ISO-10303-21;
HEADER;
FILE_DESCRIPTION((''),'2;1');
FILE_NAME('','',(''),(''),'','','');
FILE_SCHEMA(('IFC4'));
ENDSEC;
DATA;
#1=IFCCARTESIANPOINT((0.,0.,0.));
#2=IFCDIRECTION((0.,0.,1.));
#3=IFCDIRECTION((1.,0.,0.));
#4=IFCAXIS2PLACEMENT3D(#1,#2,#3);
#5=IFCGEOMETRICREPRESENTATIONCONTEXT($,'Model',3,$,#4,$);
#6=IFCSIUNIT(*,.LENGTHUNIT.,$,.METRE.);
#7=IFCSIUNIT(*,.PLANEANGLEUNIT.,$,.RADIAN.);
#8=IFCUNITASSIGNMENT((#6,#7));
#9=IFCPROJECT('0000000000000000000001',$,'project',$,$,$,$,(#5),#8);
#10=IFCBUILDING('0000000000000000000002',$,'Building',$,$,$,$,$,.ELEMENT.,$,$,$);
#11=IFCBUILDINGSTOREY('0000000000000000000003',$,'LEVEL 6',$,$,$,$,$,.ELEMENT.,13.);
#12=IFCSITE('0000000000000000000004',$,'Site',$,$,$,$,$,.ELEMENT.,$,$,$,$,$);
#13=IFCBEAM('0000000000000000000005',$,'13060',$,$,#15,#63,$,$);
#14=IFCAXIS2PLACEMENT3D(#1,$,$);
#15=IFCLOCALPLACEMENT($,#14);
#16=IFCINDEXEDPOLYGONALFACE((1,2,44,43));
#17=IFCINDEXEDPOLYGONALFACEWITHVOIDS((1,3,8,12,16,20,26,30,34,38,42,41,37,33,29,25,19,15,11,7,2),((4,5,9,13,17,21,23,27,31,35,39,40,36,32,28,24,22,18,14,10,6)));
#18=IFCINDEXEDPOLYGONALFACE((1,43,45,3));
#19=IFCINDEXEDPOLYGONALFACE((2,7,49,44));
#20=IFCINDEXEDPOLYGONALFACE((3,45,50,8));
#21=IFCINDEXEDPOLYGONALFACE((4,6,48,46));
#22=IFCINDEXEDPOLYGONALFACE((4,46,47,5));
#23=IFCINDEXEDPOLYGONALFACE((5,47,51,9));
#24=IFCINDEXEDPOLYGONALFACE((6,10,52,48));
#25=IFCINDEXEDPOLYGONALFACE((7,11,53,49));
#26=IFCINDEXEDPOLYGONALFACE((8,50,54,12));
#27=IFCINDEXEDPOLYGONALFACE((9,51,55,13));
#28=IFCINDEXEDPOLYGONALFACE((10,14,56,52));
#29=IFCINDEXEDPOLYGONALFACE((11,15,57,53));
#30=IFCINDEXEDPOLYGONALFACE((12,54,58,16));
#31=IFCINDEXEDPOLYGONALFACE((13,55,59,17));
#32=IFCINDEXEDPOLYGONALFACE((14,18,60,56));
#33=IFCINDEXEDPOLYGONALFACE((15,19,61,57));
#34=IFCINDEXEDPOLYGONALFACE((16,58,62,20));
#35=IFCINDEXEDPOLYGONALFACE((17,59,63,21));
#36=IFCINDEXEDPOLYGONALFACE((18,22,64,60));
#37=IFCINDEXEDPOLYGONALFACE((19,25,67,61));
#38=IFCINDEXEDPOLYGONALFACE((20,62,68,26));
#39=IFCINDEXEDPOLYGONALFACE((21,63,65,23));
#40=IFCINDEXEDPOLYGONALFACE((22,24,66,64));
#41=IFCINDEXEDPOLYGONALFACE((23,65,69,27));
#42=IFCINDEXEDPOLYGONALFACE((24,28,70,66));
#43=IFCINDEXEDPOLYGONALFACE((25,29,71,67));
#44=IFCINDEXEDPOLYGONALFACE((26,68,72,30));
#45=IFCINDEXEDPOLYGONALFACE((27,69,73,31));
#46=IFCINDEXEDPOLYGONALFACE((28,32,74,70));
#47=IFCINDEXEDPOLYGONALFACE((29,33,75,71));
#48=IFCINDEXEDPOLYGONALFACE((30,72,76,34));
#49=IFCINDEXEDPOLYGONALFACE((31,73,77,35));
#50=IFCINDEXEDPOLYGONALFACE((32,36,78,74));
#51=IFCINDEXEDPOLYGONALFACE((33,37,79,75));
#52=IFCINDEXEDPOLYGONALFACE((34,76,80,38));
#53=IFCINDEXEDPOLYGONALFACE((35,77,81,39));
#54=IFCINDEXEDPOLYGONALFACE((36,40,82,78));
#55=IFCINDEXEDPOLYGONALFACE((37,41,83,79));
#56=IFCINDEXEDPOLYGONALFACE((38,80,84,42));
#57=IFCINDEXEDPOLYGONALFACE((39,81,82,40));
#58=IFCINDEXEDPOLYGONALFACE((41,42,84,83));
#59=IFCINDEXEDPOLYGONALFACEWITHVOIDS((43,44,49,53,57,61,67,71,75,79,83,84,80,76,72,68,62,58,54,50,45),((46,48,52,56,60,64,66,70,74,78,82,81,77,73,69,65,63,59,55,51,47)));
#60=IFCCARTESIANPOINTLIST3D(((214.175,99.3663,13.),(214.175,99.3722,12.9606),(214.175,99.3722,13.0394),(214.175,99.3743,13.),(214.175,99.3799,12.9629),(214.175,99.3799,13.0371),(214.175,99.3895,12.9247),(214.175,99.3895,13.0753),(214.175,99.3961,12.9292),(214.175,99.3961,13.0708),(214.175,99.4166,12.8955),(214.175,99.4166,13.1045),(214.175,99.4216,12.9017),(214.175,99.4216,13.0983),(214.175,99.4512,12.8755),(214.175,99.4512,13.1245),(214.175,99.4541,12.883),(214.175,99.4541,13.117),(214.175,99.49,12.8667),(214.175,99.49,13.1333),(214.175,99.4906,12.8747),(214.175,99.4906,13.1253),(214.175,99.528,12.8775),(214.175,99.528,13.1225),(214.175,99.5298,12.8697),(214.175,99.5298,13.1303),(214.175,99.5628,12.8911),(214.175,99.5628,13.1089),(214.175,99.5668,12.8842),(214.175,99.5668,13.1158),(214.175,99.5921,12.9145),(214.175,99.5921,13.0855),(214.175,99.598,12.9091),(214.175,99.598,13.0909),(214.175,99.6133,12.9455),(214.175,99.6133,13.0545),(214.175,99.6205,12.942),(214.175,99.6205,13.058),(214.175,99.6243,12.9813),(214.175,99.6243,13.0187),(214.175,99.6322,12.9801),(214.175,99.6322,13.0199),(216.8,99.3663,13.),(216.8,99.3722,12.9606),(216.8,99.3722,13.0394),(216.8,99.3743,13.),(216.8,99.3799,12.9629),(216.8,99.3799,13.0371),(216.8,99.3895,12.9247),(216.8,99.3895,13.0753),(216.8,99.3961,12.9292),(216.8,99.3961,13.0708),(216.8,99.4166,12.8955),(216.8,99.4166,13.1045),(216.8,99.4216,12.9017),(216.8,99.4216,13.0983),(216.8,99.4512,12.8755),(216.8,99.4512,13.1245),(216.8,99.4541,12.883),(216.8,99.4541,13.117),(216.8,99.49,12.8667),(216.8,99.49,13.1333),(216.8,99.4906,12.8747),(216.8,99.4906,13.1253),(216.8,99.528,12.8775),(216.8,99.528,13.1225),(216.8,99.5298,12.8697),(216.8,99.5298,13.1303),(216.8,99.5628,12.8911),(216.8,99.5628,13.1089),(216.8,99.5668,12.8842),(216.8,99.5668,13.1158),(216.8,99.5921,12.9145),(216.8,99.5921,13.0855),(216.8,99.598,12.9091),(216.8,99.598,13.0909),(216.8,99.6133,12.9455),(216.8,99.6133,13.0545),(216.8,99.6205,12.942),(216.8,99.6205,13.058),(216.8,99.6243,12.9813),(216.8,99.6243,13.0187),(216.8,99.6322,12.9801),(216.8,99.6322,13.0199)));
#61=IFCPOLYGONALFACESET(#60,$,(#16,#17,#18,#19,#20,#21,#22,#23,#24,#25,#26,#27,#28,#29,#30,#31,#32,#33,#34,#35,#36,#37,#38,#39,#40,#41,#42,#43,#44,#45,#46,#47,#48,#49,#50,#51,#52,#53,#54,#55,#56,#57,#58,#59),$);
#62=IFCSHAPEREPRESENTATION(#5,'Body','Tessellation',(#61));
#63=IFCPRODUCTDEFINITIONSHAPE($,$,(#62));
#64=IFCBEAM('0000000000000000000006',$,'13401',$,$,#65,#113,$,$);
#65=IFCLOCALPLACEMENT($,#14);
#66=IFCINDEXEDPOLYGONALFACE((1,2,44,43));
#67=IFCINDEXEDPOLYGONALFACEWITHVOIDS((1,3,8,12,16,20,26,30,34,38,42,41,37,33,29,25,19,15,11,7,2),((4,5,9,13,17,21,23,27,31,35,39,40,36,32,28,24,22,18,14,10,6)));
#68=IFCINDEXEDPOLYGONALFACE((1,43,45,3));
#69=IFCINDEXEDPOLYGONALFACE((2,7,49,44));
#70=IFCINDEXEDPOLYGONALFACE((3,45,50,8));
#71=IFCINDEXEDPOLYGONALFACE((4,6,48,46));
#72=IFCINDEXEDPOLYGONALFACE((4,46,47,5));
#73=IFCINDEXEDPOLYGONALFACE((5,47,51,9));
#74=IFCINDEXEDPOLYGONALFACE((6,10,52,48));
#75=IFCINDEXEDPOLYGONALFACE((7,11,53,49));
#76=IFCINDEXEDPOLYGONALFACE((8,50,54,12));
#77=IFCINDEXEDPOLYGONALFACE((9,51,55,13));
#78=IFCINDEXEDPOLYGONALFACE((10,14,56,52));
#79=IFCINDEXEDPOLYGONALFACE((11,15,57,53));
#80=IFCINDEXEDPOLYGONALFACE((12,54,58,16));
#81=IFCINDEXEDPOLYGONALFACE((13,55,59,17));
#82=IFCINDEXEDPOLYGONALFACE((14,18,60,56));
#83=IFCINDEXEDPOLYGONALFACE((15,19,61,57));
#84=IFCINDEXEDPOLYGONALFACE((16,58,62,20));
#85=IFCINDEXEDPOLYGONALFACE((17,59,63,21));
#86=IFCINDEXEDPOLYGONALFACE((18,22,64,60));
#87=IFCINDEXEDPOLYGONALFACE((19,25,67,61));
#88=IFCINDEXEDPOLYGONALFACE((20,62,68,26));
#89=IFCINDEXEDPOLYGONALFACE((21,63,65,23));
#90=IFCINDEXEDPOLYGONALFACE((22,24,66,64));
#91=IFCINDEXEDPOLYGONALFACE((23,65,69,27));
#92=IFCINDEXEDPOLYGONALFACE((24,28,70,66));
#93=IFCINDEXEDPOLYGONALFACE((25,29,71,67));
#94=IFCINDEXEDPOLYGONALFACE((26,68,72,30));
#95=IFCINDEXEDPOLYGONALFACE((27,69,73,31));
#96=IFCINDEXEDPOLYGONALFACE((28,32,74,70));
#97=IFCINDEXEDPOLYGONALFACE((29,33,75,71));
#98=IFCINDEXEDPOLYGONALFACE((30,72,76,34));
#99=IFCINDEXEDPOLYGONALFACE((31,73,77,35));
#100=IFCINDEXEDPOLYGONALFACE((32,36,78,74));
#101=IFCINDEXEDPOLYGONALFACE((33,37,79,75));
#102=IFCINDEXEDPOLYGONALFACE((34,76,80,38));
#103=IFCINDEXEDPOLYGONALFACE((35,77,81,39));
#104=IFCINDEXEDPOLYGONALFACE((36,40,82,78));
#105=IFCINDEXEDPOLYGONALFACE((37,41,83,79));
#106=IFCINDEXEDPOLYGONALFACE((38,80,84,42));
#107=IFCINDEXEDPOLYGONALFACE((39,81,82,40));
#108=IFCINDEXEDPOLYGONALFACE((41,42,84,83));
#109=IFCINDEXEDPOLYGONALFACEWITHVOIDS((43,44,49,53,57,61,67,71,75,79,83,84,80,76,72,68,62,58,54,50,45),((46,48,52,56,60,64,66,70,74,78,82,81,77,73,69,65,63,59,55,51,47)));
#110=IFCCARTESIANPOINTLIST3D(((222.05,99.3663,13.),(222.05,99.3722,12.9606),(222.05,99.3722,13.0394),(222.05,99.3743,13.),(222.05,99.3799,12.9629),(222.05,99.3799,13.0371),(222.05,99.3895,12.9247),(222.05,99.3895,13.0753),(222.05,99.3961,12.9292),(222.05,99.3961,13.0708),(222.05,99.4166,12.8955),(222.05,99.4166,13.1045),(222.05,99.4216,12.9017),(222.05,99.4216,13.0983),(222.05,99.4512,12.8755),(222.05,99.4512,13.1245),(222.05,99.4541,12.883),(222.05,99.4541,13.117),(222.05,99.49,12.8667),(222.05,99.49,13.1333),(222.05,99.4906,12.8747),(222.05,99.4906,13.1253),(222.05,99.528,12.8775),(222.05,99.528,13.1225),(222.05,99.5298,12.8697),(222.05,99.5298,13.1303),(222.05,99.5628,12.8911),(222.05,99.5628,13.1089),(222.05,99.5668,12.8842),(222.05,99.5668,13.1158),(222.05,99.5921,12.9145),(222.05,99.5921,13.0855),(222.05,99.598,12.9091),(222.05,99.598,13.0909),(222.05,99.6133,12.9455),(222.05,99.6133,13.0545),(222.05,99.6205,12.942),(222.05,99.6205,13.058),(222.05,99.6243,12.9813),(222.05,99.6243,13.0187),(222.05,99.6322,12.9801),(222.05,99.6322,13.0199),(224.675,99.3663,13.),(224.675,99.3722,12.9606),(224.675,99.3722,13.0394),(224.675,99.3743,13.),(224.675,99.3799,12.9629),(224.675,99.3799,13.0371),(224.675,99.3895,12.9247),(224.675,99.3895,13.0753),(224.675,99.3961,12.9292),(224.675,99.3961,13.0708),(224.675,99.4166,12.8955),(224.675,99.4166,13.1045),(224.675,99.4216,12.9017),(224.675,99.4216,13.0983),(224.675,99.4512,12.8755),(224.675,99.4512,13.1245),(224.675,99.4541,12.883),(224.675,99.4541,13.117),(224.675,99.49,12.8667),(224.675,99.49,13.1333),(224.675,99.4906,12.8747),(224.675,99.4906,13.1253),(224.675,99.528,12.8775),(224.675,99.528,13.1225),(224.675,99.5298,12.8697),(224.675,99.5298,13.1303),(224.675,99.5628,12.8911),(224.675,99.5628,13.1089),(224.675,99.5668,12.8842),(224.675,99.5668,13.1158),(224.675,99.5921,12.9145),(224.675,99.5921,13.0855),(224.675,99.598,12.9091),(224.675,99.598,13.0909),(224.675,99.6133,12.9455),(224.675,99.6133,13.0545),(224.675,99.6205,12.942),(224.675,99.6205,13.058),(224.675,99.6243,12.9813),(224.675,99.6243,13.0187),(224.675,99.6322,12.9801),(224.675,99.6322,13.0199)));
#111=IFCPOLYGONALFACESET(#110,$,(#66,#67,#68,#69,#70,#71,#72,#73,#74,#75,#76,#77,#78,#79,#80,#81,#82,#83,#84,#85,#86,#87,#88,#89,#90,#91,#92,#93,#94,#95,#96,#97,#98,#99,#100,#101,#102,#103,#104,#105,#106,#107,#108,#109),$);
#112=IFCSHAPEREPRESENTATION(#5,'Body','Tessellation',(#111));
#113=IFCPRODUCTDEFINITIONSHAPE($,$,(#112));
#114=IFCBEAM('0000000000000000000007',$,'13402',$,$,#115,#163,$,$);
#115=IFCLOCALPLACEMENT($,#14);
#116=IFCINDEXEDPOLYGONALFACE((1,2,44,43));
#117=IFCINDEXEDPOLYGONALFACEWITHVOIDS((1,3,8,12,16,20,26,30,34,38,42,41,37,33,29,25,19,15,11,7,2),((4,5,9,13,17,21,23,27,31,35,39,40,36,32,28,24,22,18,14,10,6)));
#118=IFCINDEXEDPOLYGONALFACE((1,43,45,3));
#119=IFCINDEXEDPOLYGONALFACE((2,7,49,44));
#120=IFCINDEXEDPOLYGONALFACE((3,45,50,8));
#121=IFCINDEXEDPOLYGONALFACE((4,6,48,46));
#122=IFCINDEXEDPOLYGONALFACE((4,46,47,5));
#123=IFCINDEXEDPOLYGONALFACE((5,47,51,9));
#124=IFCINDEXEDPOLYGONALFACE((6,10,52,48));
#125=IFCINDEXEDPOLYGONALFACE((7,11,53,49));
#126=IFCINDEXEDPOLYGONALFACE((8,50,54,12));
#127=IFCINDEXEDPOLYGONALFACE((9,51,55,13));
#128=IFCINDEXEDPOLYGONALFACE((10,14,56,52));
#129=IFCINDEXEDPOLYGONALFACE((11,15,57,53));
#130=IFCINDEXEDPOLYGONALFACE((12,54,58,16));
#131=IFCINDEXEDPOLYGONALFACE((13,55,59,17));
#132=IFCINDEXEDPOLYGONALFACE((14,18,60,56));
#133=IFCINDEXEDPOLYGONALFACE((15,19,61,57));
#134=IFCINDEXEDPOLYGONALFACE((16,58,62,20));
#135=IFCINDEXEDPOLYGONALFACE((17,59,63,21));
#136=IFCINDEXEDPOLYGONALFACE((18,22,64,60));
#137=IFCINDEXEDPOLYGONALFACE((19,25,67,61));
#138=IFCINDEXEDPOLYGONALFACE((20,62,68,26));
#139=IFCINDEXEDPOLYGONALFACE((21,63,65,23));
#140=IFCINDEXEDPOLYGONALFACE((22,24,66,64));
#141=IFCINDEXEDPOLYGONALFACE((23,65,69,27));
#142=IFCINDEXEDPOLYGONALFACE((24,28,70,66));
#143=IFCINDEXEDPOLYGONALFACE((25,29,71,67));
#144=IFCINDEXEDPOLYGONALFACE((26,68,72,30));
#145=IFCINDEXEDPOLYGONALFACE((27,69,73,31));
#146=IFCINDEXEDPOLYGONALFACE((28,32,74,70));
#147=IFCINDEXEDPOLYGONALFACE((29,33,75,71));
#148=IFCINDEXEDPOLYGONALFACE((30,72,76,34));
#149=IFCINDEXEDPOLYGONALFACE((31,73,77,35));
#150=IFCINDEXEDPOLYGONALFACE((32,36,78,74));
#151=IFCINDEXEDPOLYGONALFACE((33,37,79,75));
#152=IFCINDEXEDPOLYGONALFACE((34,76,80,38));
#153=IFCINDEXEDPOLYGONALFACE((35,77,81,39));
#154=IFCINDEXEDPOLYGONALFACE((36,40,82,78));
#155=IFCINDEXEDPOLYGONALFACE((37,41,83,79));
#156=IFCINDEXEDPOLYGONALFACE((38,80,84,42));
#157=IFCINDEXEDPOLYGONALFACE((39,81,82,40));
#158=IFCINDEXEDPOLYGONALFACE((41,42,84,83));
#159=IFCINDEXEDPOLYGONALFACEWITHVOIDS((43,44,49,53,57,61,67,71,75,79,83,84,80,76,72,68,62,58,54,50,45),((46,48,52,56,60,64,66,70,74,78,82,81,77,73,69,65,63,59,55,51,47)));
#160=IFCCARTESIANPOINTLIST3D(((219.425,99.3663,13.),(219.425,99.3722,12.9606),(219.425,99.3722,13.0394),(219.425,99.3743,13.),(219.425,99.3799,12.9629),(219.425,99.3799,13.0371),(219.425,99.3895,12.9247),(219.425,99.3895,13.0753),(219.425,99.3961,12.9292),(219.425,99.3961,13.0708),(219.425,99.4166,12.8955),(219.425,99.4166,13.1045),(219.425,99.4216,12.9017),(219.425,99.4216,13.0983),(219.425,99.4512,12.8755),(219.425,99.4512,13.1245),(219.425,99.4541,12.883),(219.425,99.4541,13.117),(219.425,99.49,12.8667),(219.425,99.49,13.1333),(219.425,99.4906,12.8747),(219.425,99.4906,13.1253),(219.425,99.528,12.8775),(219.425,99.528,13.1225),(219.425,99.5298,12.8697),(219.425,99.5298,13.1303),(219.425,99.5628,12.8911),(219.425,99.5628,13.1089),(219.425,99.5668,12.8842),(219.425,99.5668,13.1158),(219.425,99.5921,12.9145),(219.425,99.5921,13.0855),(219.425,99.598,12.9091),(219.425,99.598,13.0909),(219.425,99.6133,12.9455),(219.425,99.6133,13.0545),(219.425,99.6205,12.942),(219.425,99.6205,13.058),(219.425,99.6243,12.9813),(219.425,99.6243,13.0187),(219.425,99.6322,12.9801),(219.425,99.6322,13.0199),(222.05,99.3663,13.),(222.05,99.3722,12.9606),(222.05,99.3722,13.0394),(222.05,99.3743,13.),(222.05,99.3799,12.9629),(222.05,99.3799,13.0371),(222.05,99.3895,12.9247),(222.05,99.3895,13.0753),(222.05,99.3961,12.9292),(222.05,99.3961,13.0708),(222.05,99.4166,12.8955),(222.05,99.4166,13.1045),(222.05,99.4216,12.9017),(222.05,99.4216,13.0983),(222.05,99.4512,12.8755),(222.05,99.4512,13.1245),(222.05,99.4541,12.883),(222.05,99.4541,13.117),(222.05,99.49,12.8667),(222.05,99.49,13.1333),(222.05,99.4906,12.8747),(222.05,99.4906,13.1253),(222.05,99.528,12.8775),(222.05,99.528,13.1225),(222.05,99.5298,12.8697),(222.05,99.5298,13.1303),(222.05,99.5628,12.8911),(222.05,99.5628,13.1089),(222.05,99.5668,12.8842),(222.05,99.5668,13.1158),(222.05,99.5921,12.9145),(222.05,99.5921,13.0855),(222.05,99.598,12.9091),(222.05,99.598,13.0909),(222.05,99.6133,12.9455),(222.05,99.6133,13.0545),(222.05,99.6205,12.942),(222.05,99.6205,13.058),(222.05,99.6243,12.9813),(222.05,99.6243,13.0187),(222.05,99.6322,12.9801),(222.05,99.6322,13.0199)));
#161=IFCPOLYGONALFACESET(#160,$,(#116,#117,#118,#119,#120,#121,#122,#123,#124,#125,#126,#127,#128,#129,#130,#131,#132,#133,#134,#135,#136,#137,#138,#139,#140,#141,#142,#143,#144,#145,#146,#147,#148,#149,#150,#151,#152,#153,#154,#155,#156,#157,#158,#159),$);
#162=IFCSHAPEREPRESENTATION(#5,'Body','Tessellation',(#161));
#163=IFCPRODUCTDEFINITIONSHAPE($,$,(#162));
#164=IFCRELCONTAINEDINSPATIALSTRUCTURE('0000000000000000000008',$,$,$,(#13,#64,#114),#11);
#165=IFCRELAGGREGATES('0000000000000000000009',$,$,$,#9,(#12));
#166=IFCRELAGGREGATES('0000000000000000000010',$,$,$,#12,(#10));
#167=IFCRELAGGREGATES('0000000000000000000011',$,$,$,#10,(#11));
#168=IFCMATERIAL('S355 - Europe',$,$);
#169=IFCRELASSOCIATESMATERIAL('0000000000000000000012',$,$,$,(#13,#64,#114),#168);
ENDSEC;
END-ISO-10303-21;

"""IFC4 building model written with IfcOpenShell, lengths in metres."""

from ifc_helpers import new_model, si_unit, frame, origin_with_axes, origin_2d_with_axis, place, context, project, spatial, hollow_circle, extrude, material, material_profile, profile_set, profile_usage, element, save


model = new_model("IFC4")

# Units and contexts
model_context = context("Model", 3, world=origin_with_axes())
ifc_project = project(units=[si_unit("LENGTHUNIT", "METRE"), si_unit("PLANEANGLEUNIT", "RADIAN")], contexts=[model_context])

# Site, building, storey
site = spatial("IfcSite", under=ifc_project, Name="Site", CompositionType="ELEMENT")
building = spatial("IfcBuilding", under=site, Name="Building", CompositionType="ELEMENT")
storey = spatial("IfcBuildingStorey", under=building, Name="LEVEL 6", CompositionType="ELEMENT", Elevation=13.0)

# Shared definitions
ifc_material = material(Name="S355 - Europe")

# Beams
ifc_material_profile_1 = material_profile(ifc_material, hollow_circle(Radius=0.1337, WallThickness=0.008, at=origin_2d_with_axis()))
ifc_profile_set_1 = profile_set([ifc_material_profile_1])
ifc_profile_usage_1 = profile_usage(ifc_profile_set_1, cardinal=10)
beam_1_placement = place(None, frame((216.8, 99.5, 13.0), z_axis=(-1.0, 0.0, 0.0), x_axis=(0.0, -1.0, 0.0)))
element("IfcBeam", 1, at=beam_1_placement, inside=storey, material=ifc_profile_usage_1, Name="13060", context=model_context, shape_type="SweptSolid", body=[
    extrude(hollow_circle(Radius=0.1337, WallThickness=0.008, at=origin_2d_with_axis()), origin_with_axes(), (0.0, 0.0, 1.0), 2.625),
])
ifc_material_profile_2 = material_profile(ifc_material, hollow_circle(Radius=0.1337, WallThickness=0.008, at=origin_2d_with_axis()))
ifc_profile_set_2 = profile_set([ifc_material_profile_2])
ifc_profile_usage_2 = profile_usage(ifc_profile_set_2, cardinal=10)
beam_2_placement = place(None, frame((224.675, 99.5, 13.0), z_axis=(-1.0, 0.0, 0.0), x_axis=(0.0, -1.0, 0.0)))
element("IfcBeam", 2, at=beam_2_placement, inside=storey, material=ifc_profile_usage_2, Name="13401", context=model_context, shape_type="SweptSolid", body=[
    extrude(hollow_circle(Radius=0.1337, WallThickness=0.008, at=origin_2d_with_axis()), origin_with_axes(), (0.0, 0.0, 1.0), 2.625),
])
ifc_material_profile_3 = material_profile(ifc_material, hollow_circle(Radius=0.1337, WallThickness=0.008, at=origin_2d_with_axis()))
ifc_profile_set_3 = profile_set([ifc_material_profile_3])
ifc_profile_usage_3 = profile_usage(ifc_profile_set_3, cardinal=10)
beam_3_placement = place(None, frame((222.05, 99.5, 13.0), z_axis=(-1.0, 0.0, 0.0), x_axis=(0.0, -1.0, 0.0)))
element("IfcBeam", 3, at=beam_3_placement, inside=storey, material=ifc_profile_usage_3, Name="13402", context=model_context, shape_type="SweptSolid", body=[
    extrude(hollow_circle(Radius=0.1337, WallThickness=0.008, at=origin_2d_with_axis()), origin_with_axes(), (0.0, 0.0, 1.0), 2.625),
])

save(model, "model.ifc")
